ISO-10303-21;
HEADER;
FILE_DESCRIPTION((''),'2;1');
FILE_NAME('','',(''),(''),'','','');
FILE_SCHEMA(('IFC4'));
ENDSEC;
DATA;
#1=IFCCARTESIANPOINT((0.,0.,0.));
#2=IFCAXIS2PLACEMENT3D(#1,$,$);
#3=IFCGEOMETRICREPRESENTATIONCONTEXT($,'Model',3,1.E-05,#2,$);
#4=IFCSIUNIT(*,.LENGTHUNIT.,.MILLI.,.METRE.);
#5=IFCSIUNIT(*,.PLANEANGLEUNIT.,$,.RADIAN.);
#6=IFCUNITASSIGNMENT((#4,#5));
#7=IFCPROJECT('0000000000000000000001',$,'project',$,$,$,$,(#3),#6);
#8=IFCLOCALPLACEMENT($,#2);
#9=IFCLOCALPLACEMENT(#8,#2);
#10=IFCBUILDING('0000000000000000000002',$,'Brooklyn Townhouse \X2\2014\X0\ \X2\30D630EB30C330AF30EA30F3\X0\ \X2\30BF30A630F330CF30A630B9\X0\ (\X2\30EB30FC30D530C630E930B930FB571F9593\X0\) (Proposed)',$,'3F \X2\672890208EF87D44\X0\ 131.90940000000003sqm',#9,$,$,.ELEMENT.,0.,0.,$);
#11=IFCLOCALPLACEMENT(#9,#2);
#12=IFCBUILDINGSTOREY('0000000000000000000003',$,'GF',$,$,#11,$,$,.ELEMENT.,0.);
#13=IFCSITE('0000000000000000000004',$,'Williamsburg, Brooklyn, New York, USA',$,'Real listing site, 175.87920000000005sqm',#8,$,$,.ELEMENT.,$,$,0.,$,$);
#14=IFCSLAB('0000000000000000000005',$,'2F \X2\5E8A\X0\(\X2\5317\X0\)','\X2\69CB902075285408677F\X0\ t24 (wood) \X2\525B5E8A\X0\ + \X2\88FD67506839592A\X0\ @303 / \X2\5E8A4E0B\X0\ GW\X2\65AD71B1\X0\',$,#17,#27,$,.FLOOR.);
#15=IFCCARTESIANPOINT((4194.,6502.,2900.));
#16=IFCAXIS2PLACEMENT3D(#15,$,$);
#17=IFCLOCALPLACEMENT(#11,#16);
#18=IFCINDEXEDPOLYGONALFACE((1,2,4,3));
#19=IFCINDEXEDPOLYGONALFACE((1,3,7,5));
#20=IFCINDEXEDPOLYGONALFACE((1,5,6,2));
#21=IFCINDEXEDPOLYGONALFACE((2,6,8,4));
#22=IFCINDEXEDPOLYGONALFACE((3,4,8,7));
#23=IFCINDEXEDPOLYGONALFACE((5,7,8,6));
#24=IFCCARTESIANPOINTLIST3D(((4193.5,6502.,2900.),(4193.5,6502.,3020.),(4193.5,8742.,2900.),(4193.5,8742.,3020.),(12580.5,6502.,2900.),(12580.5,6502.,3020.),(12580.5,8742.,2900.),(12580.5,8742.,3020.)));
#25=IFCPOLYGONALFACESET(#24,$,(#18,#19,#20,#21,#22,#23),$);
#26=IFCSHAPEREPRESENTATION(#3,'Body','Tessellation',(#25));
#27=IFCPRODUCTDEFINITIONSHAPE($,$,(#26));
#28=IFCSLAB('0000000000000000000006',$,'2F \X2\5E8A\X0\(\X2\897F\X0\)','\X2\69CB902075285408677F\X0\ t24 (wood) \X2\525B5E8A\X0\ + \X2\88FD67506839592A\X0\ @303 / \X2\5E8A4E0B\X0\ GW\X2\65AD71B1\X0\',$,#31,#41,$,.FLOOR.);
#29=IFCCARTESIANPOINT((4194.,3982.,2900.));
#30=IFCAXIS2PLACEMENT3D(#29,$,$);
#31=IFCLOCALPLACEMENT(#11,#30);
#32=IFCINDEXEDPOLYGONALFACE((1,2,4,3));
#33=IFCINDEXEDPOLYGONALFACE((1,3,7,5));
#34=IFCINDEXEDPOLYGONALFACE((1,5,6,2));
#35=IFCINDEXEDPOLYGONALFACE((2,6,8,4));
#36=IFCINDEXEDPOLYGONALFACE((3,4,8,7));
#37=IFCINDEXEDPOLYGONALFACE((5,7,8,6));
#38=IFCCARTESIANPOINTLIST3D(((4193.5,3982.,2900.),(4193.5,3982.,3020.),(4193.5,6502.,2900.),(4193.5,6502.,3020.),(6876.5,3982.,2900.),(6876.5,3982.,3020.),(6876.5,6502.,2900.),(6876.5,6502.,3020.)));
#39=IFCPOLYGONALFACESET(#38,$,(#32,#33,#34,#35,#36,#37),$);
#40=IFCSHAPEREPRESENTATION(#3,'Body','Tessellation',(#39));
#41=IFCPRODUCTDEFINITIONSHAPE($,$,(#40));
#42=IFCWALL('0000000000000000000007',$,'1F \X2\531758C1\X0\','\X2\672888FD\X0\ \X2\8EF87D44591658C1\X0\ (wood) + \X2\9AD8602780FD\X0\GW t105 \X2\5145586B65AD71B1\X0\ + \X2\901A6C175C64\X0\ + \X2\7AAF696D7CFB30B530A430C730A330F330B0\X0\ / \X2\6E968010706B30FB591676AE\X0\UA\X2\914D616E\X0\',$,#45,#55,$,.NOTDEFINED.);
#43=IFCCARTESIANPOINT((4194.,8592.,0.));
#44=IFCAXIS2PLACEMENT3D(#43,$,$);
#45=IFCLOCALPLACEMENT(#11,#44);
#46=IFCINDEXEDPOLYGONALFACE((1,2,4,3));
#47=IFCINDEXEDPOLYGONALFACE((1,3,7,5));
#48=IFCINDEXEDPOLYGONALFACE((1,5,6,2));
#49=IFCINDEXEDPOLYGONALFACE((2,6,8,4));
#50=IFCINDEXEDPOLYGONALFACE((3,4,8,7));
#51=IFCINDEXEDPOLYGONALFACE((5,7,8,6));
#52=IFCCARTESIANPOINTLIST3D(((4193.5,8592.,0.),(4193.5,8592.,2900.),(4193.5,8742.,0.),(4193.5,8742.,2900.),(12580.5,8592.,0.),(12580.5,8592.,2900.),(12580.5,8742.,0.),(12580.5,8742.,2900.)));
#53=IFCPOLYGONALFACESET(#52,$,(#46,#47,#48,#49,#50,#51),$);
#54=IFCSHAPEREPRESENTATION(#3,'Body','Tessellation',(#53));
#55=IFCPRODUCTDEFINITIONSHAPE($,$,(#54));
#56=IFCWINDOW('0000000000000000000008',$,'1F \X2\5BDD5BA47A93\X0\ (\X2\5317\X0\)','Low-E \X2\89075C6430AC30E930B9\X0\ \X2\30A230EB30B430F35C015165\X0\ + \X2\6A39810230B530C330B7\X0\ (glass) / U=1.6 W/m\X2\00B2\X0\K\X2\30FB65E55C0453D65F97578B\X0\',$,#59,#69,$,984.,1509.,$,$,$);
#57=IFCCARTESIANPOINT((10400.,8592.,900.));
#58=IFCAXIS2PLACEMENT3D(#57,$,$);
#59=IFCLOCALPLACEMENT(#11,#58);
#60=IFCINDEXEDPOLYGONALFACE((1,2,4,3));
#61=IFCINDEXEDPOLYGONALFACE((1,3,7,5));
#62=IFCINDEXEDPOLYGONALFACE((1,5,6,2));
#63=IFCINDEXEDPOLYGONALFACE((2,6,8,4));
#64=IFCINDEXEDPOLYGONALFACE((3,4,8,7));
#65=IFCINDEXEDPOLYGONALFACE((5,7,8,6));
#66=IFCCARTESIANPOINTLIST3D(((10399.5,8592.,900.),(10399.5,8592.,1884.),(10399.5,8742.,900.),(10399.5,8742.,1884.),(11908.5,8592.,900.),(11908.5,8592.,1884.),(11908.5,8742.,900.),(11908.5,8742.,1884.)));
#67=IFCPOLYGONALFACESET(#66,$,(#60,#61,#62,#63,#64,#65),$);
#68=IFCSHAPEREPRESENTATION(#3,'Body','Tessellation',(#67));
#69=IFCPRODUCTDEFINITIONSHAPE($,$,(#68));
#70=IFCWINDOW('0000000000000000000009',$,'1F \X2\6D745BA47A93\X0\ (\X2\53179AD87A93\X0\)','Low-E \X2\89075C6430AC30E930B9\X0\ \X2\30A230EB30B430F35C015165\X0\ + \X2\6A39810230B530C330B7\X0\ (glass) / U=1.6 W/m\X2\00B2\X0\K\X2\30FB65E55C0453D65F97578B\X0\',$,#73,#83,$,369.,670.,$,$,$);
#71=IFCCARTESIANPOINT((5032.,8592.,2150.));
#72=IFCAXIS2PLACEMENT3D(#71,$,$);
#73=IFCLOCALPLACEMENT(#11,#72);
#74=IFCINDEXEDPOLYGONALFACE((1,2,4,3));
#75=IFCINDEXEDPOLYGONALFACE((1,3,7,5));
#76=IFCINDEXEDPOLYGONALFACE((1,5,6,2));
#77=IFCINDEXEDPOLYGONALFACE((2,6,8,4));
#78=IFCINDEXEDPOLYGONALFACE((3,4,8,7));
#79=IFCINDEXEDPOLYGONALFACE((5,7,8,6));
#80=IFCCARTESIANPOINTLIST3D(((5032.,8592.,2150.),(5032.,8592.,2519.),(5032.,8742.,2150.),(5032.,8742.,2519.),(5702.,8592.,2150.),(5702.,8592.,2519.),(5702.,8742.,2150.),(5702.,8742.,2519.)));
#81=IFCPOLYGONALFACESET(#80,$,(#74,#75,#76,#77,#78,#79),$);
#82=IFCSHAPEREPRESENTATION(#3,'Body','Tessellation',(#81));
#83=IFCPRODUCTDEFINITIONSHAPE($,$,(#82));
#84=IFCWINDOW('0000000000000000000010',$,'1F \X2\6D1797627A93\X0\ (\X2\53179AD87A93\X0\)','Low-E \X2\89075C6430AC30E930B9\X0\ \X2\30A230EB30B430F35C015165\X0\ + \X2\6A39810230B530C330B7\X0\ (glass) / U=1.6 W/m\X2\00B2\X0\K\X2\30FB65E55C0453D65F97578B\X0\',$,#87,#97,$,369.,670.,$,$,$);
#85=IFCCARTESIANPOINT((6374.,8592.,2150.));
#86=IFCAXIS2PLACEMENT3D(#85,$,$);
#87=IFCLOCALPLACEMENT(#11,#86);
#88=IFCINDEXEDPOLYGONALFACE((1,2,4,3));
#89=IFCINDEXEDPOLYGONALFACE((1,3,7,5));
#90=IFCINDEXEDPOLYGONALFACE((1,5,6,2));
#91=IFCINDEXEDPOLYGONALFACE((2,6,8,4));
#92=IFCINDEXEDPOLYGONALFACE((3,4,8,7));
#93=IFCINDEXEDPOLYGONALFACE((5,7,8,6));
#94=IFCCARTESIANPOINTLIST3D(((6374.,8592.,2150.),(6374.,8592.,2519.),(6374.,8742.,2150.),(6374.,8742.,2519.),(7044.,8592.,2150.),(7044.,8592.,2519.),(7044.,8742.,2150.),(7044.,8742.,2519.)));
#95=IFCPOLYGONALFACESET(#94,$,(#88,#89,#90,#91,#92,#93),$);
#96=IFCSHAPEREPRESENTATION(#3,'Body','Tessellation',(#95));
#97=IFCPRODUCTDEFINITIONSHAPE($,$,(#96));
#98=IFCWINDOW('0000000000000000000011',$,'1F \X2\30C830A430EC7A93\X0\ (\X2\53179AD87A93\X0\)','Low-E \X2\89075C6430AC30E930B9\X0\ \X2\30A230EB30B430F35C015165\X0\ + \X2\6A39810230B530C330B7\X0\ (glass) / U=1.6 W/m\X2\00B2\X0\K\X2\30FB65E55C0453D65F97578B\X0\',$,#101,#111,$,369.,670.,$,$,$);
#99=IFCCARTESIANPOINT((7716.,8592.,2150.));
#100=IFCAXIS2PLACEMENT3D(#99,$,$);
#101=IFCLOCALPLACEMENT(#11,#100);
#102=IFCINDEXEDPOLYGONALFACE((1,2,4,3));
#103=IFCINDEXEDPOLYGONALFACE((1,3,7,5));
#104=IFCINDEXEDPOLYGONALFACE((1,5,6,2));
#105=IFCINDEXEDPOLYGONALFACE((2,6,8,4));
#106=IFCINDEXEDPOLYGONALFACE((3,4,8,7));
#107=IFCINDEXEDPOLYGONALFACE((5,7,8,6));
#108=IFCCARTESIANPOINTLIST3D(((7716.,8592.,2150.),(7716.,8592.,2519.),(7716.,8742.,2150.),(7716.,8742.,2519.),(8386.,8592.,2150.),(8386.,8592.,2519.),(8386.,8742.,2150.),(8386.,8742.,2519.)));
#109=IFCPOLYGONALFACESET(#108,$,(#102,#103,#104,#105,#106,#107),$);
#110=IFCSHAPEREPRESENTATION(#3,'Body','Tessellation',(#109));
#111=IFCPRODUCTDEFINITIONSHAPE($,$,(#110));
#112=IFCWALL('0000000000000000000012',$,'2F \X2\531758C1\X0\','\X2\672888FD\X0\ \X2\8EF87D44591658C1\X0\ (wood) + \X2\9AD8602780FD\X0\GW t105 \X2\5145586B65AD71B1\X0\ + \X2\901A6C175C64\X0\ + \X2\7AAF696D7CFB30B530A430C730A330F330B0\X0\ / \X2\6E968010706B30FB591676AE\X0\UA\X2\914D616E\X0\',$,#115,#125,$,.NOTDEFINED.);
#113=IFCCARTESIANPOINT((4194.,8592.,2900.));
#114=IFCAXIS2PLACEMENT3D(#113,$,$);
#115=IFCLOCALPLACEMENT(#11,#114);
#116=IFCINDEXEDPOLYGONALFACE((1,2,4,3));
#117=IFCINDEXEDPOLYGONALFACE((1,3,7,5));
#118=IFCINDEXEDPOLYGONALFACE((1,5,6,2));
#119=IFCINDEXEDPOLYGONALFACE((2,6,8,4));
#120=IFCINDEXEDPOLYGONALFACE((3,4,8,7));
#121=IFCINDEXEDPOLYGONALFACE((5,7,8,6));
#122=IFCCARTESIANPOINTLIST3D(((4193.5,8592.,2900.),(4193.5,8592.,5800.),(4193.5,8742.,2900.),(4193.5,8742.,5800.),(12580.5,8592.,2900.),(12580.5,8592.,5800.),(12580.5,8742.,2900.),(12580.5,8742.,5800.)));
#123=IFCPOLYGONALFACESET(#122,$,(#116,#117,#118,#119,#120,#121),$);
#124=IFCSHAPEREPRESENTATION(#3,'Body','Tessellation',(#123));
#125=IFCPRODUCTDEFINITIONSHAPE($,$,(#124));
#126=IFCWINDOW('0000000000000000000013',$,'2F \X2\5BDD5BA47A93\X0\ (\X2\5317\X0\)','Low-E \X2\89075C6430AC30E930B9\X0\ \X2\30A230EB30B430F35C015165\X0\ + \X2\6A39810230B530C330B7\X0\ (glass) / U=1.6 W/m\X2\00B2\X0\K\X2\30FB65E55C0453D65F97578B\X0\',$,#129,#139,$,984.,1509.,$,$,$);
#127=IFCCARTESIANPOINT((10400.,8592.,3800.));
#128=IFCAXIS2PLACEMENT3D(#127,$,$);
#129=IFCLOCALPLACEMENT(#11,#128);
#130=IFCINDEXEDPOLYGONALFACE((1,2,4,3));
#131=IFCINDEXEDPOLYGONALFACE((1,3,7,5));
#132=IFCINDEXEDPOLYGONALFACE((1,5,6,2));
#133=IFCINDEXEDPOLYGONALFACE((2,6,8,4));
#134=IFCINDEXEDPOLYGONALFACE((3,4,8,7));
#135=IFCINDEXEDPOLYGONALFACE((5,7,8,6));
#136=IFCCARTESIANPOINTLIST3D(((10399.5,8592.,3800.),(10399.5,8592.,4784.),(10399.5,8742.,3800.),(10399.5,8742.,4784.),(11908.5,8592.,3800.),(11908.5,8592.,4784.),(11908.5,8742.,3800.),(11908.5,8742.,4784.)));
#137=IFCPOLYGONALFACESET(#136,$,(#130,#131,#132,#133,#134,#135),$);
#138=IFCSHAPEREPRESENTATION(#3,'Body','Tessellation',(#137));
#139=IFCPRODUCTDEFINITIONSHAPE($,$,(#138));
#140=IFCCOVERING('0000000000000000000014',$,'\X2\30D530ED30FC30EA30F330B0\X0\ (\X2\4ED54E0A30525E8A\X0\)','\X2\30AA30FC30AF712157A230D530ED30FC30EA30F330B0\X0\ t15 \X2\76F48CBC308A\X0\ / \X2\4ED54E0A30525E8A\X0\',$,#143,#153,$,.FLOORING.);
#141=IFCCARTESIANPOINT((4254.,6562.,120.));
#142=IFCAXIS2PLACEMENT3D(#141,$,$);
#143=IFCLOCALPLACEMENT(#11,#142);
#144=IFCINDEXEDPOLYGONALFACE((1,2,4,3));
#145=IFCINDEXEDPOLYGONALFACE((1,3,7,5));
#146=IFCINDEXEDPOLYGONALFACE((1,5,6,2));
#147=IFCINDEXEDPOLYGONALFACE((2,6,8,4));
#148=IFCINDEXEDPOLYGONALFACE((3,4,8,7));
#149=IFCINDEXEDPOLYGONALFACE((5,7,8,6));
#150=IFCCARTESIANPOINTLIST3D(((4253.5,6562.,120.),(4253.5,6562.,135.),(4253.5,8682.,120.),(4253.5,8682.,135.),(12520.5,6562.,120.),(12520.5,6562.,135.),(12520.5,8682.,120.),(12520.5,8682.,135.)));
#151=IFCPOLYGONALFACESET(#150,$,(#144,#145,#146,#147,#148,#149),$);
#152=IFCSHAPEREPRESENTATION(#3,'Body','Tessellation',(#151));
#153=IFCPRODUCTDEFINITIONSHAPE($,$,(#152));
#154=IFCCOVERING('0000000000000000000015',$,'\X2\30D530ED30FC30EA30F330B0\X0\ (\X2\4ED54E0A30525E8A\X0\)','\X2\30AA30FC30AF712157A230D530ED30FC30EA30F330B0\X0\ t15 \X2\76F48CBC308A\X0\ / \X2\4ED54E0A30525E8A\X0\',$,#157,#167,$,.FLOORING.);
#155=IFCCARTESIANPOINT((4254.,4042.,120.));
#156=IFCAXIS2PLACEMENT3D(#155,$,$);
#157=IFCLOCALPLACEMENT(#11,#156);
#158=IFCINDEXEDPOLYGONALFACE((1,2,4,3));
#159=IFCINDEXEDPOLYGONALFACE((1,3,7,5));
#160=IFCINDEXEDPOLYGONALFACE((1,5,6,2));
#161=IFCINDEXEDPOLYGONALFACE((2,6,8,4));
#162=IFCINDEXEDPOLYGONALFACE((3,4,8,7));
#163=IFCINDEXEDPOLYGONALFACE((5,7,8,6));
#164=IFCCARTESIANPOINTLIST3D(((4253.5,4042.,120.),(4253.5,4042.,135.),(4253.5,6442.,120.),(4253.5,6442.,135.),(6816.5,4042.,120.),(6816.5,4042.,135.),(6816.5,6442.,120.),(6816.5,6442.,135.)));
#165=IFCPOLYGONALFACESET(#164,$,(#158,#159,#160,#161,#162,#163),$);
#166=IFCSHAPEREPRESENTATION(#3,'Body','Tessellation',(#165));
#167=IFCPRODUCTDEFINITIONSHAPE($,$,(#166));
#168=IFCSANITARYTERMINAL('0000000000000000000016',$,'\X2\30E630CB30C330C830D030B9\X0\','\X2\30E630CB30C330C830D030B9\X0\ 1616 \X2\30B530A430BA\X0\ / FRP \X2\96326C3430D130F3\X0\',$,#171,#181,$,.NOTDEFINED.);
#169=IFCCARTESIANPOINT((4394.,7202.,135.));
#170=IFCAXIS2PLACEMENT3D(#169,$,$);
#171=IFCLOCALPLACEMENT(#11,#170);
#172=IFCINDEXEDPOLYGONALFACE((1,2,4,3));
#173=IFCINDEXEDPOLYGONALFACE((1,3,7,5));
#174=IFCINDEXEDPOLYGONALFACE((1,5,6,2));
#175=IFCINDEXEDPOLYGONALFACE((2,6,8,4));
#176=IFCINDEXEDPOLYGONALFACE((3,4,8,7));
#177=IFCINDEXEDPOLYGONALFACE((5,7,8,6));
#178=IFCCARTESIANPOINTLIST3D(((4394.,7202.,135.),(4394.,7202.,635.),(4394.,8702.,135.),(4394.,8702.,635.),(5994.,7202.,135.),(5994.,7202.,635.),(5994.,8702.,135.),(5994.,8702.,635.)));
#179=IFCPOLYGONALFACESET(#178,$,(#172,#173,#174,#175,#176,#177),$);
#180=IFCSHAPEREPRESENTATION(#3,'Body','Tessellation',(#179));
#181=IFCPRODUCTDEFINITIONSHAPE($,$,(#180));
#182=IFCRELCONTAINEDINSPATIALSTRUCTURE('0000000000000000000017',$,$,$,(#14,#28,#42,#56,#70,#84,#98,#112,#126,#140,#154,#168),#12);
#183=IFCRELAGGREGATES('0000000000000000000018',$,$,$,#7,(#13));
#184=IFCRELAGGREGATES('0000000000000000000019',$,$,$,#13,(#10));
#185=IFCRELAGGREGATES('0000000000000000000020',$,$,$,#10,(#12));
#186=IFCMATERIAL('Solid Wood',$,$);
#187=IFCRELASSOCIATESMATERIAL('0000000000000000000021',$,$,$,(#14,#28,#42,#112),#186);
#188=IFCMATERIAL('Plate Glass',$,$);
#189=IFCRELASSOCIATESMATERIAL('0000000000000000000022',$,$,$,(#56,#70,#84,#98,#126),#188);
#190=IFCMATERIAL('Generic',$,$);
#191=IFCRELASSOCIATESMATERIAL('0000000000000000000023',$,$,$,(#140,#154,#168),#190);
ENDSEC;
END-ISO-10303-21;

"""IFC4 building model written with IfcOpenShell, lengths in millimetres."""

from ifc_helpers import new_model, si_unit, frame, frame_2d, origin, place, context, project, spatial, rectangle, extrude, material, element, fill, save


model = new_model("IFC4")

# Units and contexts
model_context = context("Model", 3, precision=1e-05, world=origin())
ifc_project = project(units=[si_unit("LENGTHUNIT", "METRE", prefix="MILLI"), si_unit("PLANEANGLEUNIT", "RADIAN")], contexts=[model_context])

# Site, building, storey
site_placement = place(None, origin())
site = spatial("IfcSite", under=ifc_project, at=site_placement, Name="Williamsburg, Brooklyn, New York, USA", ObjectType="Real listing site, 175.87920000000005sqm", CompositionType="ELEMENT", RefElevation=0.0)
building_placement = place(site_placement, origin())
building = spatial("IfcBuilding", under=site, at=building_placement, Name="Brooklyn Townhouse — ブルックリン タウンハウス (ルーフテラス・土間) (Proposed)", ObjectType="3F 木造軸組 131.90940000000003sqm", CompositionType="ELEMENT", ElevationOfRefHeight=0.0, ElevationOfTerrain=0.0)
storey_placement = place(building_placement, origin())
storey = spatial("IfcBuildingStorey", under=building, at=storey_placement, Name="GF", CompositionType="ELEMENT", Elevation=0.0)

# Slabs
ifc_material_1 = material(Name="Solid Wood")
slab_1_placement = place(storey_placement, frame((4194.0, 6502.0, 2900.0)))
element("IfcSlab", 1, at=slab_1_placement, inside=storey, material=ifc_material_1, Name="2F 床(北)", Description="構造用合板 t24 (wood) 剛床 + 製材根太 @303 / 床下 GW断熱", PredefinedType="FLOOR", context=model_context, shape_type="SweptSolid", body=[
    extrude(rectangle(XDim=8387.0, YDim=2240.0, at=frame_2d((4193.0, 1120.0))), frame((4194.0, 6502.0, 2900.0)), (0.0, 0.0, 1.0), 120.0),
])
slab_2_placement = place(storey_placement, frame((4194.0, 3982.0, 2900.0)))
element("IfcSlab", 2, at=slab_2_placement, inside=storey, material=ifc_material_1, Name="2F 床(西)", Description="構造用合板 t24 (wood) 剛床 + 製材根太 @303 / 床下 GW断熱", PredefinedType="FLOOR", context=model_context, shape_type="SweptSolid", body=[
    extrude(rectangle(XDim=2683.0, YDim=2520.0, at=frame_2d((1341.0, 1260.0))), frame((4194.0, 3982.0, 2900.0)), (0.0, 0.0, 1.0), 120.0),
])

# Wall, openings, windows
wall_1_placement = place(storey_placement, frame((4194.0, 8592.0, 0.0)))
wall_1 = element("IfcWall", 3, at=wall_1_placement, inside=storey, material=ifc_material_1, Name="1F 北壁", Description="木製 軸組外壁 (wood) + 高性能GW t105 充填断熱 + 通気層 + 窯業系サイディング / 準耐火・外皮UA配慮", PredefinedType="NOTDEFINED", context=model_context, shape_type="SweptSolid", body=[
    extrude(rectangle(XDim=8387.0, YDim=150.0, at=frame_2d((4193.0, 75.0))), frame((4194.0, 8592.0, 0.0)), (0.0, 0.0, 1.0), 2900.0),
])
opening_1_placement = place(storey_placement, frame((10400.0, 8592.0, 900.0)))
opening_1 = element("IfcOpeningElement", 4, at=opening_1_placement, cuts=wall_1, PredefinedType="NOTDEFINED", context=model_context, shape_type="SweptSolid", body=[
    extrude(rectangle(XDim=1509.0, YDim=150.0, at=frame_2d((754.0, 75.0))), frame((10400.0, 8592.0, 900.0)), (0.0, 0.0, 1.0), 984.0),
])
opening_2_placement = place(storey_placement, frame((5032.0, 8592.0, 2150.0)))
opening_2 = element("IfcOpeningElement", 5, at=opening_2_placement, cuts=wall_1, PredefinedType="NOTDEFINED", context=model_context, shape_type="SweptSolid", body=[
    extrude(rectangle(XDim=670.0, YDim=150.0, at=frame_2d((335.0, 75.0))), frame((5032.0, 8592.0, 2150.0)), (0.0, 0.0, 1.0), 369.0),
])
opening_3_placement = place(storey_placement, frame((6374.0, 8592.0, 2150.0)))
opening_3 = element("IfcOpeningElement", 6, at=opening_3_placement, cuts=wall_1, PredefinedType="NOTDEFINED", context=model_context, shape_type="SweptSolid", body=[
    extrude(rectangle(XDim=670.0, YDim=150.0, at=frame_2d((335.0, 75.0))), frame((6374.0, 8592.0, 2150.0)), (0.0, 0.0, 1.0), 369.0),
])
opening_4_placement = place(storey_placement, frame((7716.0, 8592.0, 2150.0)))
opening_4 = element("IfcOpeningElement", 7, at=opening_4_placement, cuts=wall_1, PredefinedType="NOTDEFINED", context=model_context, shape_type="SweptSolid", body=[
    extrude(rectangle(XDim=670.0, YDim=150.0, at=frame_2d((335.0, 75.0))), frame((7716.0, 8592.0, 2150.0)), (0.0, 0.0, 1.0), 369.0),
])
ifc_material_2 = material(Name="Plate Glass")
window_1_placement = place(storey_placement, frame((10400.0, 8592.0, 900.0)))
window_1 = element("IfcWindow", 8, at=window_1_placement, inside=storey, material=ifc_material_2, Name="1F 寝室窓 (北)", Description="Low-E 複層ガラス アルゴン封入 + 樹脂サッシ (glass) / U=1.6 W/m²K・日射取得型", OverallHeight=984.0, OverallWidth=1509.0, context=model_context, shape_type="SweptSolid", body=[
    extrude(rectangle(XDim=1509.0, YDim=150.0, at=frame_2d((754.0, 75.0))), frame((10400.0, 8592.0, 900.0)), (0.0, 0.0, 1.0), 984.0),
])
fill(opening_1, window_1)
window_2_placement = place(storey_placement, frame((5032.0, 8592.0, 2150.0)))
window_2 = element("IfcWindow", 9, at=window_2_placement, inside=storey, material=ifc_material_2, Name="1F 浴室窓 (北高窓)", Description="Low-E 複層ガラス アルゴン封入 + 樹脂サッシ (glass) / U=1.6 W/m²K・日射取得型", OverallHeight=369.0, OverallWidth=670.0, context=model_context, shape_type="SweptSolid", body=[
    extrude(rectangle(XDim=670.0, YDim=150.0, at=frame_2d((335.0, 75.0))), frame((5032.0, 8592.0, 2150.0)), (0.0, 0.0, 1.0), 369.0),
])
fill(opening_2, window_2)
window_3_placement = place(storey_placement, frame((6374.0, 8592.0, 2150.0)))
window_3 = element("IfcWindow", 10, at=window_3_placement, inside=storey, material=ifc_material_2, Name="1F 洗面窓 (北高窓)", Description="Low-E 複層ガラス アルゴン封入 + 樹脂サッシ (glass) / U=1.6 W/m²K・日射取得型", OverallHeight=369.0, OverallWidth=670.0, context=model_context, shape_type="SweptSolid", body=[
    extrude(rectangle(XDim=670.0, YDim=150.0, at=frame_2d((335.0, 75.0))), frame((6374.0, 8592.0, 2150.0)), (0.0, 0.0, 1.0), 369.0),
])
fill(opening_3, window_3)
window_4_placement = place(storey_placement, frame((7716.0, 8592.0, 2150.0)))
window_4 = element("IfcWindow", 11, at=window_4_placement, inside=storey, material=ifc_material_2, Name="1F トイレ窓 (北高窓)", Description="Low-E 複層ガラス アルゴン封入 + 樹脂サッシ (glass) / U=1.6 W/m²K・日射取得型", OverallHeight=369.0, OverallWidth=670.0, context=model_context, shape_type="SweptSolid", body=[
    extrude(rectangle(XDim=670.0, YDim=150.0, at=frame_2d((335.0, 75.0))), frame((7716.0, 8592.0, 2150.0)), (0.0, 0.0, 1.0), 369.0),
])
fill(opening_4, window_4)

# Wall, opening, window
wall_2_placement = place(storey_placement, frame((4194.0, 8592.0, 2900.0)))
wall_2 = element("IfcWall", 12, at=wall_2_placement, inside=storey, material=ifc_material_1, Name="2F 北壁", Description="木製 軸組外壁 (wood) + 高性能GW t105 充填断熱 + 通気層 + 窯業系サイディング / 準耐火・外皮UA配慮", PredefinedType="NOTDEFINED", context=model_context, shape_type="SweptSolid", body=[
    extrude(rectangle(XDim=8387.0, YDim=150.0, at=frame_2d((4193.0, 75.0))), frame((4194.0, 8592.0, 2900.0)), (0.0, 0.0, 1.0), 2900.0),
])
opening_5_placement = place(storey_placement, frame((10400.0, 8592.0, 3800.0)))
opening_5 = element("IfcOpeningElement", 13, at=opening_5_placement, cuts=wall_2, PredefinedType="NOTDEFINED", context=model_context, shape_type="SweptSolid", body=[
    extrude(rectangle(XDim=1509.0, YDim=150.0, at=frame_2d((754.0, 75.0))), frame((10400.0, 8592.0, 3800.0)), (0.0, 0.0, 1.0), 984.0),
])
window_5_placement = place(storey_placement, frame((10400.0, 8592.0, 3800.0)))
window_5 = element("IfcWindow", 14, at=window_5_placement, inside=storey, material=ifc_material_2, Name="2F 寝室窓 (北)", Description="Low-E 複層ガラス アルゴン封入 + 樹脂サッシ (glass) / U=1.6 W/m²K・日射取得型", OverallHeight=984.0, OverallWidth=1509.0, context=model_context, shape_type="SweptSolid", body=[
    extrude(rectangle(XDim=1509.0, YDim=150.0, at=frame_2d((754.0, 75.0))), frame((10400.0, 8592.0, 3800.0)), (0.0, 0.0, 1.0), 984.0),
])
fill(opening_5, window_5)

# Coverings
ifc_material_3 = material(Name="Generic")
covering_1_placement = place(storey_placement, frame((4254.0, 6562.0, 120.0)))
element("IfcCovering", 15, at=covering_1_placement, inside=storey, material=ifc_material_3, Name="フローリング (仕上げ床)", Description="オーク無垢フローリング t15 直貼り / 仕上げ床", PredefinedType="FLOORING", context=model_context, shape_type="SweptSolid", body=[
    extrude(rectangle(XDim=8267.0, YDim=2120.0, at=frame_2d((4133.0, 1060.0))), frame((4254.0, 6562.0, 120.0)), (0.0, 0.0, 1.0), 15.0),
])
covering_2_placement = place(storey_placement, frame((4254.0, 4042.0, 120.0)))
element("IfcCovering", 16, at=covering_2_placement, inside=storey, material=ifc_material_3, Name="フローリング (仕上げ床)", Description="オーク無垢フローリング t15 直貼り / 仕上げ床", PredefinedType="FLOORING", context=model_context, shape_type="SweptSolid", body=[
    extrude(rectangle(XDim=2563.0, YDim=2400.0, at=frame_2d((1281.0, 1200.0))), frame((4254.0, 4042.0, 120.0)), (0.0, 0.0, 1.0), 15.0),
])

# Sanitary terminal
sanitary_terminal_1_placement = place(storey_placement, frame((4394.0, 7202.0, 135.0)))
element("IfcSanitaryTerminal", 17, at=sanitary_terminal_1_placement, inside=storey, material=ifc_material_3, Name="ユニットバス", Description="ユニットバス 1616 サイズ / FRP 防水パン", PredefinedType="NOTDEFINED", context=model_context, shape_type="SweptSolid", body=[
    extrude(rectangle(XDim=1600.0, YDim=1500.0, at=frame_2d((800.0, 750.0))), frame((4394.0, 7202.0, 135.0)), (0.0, 0.0, 1.0), 500.0),
])

save(model, "model.ifc")
